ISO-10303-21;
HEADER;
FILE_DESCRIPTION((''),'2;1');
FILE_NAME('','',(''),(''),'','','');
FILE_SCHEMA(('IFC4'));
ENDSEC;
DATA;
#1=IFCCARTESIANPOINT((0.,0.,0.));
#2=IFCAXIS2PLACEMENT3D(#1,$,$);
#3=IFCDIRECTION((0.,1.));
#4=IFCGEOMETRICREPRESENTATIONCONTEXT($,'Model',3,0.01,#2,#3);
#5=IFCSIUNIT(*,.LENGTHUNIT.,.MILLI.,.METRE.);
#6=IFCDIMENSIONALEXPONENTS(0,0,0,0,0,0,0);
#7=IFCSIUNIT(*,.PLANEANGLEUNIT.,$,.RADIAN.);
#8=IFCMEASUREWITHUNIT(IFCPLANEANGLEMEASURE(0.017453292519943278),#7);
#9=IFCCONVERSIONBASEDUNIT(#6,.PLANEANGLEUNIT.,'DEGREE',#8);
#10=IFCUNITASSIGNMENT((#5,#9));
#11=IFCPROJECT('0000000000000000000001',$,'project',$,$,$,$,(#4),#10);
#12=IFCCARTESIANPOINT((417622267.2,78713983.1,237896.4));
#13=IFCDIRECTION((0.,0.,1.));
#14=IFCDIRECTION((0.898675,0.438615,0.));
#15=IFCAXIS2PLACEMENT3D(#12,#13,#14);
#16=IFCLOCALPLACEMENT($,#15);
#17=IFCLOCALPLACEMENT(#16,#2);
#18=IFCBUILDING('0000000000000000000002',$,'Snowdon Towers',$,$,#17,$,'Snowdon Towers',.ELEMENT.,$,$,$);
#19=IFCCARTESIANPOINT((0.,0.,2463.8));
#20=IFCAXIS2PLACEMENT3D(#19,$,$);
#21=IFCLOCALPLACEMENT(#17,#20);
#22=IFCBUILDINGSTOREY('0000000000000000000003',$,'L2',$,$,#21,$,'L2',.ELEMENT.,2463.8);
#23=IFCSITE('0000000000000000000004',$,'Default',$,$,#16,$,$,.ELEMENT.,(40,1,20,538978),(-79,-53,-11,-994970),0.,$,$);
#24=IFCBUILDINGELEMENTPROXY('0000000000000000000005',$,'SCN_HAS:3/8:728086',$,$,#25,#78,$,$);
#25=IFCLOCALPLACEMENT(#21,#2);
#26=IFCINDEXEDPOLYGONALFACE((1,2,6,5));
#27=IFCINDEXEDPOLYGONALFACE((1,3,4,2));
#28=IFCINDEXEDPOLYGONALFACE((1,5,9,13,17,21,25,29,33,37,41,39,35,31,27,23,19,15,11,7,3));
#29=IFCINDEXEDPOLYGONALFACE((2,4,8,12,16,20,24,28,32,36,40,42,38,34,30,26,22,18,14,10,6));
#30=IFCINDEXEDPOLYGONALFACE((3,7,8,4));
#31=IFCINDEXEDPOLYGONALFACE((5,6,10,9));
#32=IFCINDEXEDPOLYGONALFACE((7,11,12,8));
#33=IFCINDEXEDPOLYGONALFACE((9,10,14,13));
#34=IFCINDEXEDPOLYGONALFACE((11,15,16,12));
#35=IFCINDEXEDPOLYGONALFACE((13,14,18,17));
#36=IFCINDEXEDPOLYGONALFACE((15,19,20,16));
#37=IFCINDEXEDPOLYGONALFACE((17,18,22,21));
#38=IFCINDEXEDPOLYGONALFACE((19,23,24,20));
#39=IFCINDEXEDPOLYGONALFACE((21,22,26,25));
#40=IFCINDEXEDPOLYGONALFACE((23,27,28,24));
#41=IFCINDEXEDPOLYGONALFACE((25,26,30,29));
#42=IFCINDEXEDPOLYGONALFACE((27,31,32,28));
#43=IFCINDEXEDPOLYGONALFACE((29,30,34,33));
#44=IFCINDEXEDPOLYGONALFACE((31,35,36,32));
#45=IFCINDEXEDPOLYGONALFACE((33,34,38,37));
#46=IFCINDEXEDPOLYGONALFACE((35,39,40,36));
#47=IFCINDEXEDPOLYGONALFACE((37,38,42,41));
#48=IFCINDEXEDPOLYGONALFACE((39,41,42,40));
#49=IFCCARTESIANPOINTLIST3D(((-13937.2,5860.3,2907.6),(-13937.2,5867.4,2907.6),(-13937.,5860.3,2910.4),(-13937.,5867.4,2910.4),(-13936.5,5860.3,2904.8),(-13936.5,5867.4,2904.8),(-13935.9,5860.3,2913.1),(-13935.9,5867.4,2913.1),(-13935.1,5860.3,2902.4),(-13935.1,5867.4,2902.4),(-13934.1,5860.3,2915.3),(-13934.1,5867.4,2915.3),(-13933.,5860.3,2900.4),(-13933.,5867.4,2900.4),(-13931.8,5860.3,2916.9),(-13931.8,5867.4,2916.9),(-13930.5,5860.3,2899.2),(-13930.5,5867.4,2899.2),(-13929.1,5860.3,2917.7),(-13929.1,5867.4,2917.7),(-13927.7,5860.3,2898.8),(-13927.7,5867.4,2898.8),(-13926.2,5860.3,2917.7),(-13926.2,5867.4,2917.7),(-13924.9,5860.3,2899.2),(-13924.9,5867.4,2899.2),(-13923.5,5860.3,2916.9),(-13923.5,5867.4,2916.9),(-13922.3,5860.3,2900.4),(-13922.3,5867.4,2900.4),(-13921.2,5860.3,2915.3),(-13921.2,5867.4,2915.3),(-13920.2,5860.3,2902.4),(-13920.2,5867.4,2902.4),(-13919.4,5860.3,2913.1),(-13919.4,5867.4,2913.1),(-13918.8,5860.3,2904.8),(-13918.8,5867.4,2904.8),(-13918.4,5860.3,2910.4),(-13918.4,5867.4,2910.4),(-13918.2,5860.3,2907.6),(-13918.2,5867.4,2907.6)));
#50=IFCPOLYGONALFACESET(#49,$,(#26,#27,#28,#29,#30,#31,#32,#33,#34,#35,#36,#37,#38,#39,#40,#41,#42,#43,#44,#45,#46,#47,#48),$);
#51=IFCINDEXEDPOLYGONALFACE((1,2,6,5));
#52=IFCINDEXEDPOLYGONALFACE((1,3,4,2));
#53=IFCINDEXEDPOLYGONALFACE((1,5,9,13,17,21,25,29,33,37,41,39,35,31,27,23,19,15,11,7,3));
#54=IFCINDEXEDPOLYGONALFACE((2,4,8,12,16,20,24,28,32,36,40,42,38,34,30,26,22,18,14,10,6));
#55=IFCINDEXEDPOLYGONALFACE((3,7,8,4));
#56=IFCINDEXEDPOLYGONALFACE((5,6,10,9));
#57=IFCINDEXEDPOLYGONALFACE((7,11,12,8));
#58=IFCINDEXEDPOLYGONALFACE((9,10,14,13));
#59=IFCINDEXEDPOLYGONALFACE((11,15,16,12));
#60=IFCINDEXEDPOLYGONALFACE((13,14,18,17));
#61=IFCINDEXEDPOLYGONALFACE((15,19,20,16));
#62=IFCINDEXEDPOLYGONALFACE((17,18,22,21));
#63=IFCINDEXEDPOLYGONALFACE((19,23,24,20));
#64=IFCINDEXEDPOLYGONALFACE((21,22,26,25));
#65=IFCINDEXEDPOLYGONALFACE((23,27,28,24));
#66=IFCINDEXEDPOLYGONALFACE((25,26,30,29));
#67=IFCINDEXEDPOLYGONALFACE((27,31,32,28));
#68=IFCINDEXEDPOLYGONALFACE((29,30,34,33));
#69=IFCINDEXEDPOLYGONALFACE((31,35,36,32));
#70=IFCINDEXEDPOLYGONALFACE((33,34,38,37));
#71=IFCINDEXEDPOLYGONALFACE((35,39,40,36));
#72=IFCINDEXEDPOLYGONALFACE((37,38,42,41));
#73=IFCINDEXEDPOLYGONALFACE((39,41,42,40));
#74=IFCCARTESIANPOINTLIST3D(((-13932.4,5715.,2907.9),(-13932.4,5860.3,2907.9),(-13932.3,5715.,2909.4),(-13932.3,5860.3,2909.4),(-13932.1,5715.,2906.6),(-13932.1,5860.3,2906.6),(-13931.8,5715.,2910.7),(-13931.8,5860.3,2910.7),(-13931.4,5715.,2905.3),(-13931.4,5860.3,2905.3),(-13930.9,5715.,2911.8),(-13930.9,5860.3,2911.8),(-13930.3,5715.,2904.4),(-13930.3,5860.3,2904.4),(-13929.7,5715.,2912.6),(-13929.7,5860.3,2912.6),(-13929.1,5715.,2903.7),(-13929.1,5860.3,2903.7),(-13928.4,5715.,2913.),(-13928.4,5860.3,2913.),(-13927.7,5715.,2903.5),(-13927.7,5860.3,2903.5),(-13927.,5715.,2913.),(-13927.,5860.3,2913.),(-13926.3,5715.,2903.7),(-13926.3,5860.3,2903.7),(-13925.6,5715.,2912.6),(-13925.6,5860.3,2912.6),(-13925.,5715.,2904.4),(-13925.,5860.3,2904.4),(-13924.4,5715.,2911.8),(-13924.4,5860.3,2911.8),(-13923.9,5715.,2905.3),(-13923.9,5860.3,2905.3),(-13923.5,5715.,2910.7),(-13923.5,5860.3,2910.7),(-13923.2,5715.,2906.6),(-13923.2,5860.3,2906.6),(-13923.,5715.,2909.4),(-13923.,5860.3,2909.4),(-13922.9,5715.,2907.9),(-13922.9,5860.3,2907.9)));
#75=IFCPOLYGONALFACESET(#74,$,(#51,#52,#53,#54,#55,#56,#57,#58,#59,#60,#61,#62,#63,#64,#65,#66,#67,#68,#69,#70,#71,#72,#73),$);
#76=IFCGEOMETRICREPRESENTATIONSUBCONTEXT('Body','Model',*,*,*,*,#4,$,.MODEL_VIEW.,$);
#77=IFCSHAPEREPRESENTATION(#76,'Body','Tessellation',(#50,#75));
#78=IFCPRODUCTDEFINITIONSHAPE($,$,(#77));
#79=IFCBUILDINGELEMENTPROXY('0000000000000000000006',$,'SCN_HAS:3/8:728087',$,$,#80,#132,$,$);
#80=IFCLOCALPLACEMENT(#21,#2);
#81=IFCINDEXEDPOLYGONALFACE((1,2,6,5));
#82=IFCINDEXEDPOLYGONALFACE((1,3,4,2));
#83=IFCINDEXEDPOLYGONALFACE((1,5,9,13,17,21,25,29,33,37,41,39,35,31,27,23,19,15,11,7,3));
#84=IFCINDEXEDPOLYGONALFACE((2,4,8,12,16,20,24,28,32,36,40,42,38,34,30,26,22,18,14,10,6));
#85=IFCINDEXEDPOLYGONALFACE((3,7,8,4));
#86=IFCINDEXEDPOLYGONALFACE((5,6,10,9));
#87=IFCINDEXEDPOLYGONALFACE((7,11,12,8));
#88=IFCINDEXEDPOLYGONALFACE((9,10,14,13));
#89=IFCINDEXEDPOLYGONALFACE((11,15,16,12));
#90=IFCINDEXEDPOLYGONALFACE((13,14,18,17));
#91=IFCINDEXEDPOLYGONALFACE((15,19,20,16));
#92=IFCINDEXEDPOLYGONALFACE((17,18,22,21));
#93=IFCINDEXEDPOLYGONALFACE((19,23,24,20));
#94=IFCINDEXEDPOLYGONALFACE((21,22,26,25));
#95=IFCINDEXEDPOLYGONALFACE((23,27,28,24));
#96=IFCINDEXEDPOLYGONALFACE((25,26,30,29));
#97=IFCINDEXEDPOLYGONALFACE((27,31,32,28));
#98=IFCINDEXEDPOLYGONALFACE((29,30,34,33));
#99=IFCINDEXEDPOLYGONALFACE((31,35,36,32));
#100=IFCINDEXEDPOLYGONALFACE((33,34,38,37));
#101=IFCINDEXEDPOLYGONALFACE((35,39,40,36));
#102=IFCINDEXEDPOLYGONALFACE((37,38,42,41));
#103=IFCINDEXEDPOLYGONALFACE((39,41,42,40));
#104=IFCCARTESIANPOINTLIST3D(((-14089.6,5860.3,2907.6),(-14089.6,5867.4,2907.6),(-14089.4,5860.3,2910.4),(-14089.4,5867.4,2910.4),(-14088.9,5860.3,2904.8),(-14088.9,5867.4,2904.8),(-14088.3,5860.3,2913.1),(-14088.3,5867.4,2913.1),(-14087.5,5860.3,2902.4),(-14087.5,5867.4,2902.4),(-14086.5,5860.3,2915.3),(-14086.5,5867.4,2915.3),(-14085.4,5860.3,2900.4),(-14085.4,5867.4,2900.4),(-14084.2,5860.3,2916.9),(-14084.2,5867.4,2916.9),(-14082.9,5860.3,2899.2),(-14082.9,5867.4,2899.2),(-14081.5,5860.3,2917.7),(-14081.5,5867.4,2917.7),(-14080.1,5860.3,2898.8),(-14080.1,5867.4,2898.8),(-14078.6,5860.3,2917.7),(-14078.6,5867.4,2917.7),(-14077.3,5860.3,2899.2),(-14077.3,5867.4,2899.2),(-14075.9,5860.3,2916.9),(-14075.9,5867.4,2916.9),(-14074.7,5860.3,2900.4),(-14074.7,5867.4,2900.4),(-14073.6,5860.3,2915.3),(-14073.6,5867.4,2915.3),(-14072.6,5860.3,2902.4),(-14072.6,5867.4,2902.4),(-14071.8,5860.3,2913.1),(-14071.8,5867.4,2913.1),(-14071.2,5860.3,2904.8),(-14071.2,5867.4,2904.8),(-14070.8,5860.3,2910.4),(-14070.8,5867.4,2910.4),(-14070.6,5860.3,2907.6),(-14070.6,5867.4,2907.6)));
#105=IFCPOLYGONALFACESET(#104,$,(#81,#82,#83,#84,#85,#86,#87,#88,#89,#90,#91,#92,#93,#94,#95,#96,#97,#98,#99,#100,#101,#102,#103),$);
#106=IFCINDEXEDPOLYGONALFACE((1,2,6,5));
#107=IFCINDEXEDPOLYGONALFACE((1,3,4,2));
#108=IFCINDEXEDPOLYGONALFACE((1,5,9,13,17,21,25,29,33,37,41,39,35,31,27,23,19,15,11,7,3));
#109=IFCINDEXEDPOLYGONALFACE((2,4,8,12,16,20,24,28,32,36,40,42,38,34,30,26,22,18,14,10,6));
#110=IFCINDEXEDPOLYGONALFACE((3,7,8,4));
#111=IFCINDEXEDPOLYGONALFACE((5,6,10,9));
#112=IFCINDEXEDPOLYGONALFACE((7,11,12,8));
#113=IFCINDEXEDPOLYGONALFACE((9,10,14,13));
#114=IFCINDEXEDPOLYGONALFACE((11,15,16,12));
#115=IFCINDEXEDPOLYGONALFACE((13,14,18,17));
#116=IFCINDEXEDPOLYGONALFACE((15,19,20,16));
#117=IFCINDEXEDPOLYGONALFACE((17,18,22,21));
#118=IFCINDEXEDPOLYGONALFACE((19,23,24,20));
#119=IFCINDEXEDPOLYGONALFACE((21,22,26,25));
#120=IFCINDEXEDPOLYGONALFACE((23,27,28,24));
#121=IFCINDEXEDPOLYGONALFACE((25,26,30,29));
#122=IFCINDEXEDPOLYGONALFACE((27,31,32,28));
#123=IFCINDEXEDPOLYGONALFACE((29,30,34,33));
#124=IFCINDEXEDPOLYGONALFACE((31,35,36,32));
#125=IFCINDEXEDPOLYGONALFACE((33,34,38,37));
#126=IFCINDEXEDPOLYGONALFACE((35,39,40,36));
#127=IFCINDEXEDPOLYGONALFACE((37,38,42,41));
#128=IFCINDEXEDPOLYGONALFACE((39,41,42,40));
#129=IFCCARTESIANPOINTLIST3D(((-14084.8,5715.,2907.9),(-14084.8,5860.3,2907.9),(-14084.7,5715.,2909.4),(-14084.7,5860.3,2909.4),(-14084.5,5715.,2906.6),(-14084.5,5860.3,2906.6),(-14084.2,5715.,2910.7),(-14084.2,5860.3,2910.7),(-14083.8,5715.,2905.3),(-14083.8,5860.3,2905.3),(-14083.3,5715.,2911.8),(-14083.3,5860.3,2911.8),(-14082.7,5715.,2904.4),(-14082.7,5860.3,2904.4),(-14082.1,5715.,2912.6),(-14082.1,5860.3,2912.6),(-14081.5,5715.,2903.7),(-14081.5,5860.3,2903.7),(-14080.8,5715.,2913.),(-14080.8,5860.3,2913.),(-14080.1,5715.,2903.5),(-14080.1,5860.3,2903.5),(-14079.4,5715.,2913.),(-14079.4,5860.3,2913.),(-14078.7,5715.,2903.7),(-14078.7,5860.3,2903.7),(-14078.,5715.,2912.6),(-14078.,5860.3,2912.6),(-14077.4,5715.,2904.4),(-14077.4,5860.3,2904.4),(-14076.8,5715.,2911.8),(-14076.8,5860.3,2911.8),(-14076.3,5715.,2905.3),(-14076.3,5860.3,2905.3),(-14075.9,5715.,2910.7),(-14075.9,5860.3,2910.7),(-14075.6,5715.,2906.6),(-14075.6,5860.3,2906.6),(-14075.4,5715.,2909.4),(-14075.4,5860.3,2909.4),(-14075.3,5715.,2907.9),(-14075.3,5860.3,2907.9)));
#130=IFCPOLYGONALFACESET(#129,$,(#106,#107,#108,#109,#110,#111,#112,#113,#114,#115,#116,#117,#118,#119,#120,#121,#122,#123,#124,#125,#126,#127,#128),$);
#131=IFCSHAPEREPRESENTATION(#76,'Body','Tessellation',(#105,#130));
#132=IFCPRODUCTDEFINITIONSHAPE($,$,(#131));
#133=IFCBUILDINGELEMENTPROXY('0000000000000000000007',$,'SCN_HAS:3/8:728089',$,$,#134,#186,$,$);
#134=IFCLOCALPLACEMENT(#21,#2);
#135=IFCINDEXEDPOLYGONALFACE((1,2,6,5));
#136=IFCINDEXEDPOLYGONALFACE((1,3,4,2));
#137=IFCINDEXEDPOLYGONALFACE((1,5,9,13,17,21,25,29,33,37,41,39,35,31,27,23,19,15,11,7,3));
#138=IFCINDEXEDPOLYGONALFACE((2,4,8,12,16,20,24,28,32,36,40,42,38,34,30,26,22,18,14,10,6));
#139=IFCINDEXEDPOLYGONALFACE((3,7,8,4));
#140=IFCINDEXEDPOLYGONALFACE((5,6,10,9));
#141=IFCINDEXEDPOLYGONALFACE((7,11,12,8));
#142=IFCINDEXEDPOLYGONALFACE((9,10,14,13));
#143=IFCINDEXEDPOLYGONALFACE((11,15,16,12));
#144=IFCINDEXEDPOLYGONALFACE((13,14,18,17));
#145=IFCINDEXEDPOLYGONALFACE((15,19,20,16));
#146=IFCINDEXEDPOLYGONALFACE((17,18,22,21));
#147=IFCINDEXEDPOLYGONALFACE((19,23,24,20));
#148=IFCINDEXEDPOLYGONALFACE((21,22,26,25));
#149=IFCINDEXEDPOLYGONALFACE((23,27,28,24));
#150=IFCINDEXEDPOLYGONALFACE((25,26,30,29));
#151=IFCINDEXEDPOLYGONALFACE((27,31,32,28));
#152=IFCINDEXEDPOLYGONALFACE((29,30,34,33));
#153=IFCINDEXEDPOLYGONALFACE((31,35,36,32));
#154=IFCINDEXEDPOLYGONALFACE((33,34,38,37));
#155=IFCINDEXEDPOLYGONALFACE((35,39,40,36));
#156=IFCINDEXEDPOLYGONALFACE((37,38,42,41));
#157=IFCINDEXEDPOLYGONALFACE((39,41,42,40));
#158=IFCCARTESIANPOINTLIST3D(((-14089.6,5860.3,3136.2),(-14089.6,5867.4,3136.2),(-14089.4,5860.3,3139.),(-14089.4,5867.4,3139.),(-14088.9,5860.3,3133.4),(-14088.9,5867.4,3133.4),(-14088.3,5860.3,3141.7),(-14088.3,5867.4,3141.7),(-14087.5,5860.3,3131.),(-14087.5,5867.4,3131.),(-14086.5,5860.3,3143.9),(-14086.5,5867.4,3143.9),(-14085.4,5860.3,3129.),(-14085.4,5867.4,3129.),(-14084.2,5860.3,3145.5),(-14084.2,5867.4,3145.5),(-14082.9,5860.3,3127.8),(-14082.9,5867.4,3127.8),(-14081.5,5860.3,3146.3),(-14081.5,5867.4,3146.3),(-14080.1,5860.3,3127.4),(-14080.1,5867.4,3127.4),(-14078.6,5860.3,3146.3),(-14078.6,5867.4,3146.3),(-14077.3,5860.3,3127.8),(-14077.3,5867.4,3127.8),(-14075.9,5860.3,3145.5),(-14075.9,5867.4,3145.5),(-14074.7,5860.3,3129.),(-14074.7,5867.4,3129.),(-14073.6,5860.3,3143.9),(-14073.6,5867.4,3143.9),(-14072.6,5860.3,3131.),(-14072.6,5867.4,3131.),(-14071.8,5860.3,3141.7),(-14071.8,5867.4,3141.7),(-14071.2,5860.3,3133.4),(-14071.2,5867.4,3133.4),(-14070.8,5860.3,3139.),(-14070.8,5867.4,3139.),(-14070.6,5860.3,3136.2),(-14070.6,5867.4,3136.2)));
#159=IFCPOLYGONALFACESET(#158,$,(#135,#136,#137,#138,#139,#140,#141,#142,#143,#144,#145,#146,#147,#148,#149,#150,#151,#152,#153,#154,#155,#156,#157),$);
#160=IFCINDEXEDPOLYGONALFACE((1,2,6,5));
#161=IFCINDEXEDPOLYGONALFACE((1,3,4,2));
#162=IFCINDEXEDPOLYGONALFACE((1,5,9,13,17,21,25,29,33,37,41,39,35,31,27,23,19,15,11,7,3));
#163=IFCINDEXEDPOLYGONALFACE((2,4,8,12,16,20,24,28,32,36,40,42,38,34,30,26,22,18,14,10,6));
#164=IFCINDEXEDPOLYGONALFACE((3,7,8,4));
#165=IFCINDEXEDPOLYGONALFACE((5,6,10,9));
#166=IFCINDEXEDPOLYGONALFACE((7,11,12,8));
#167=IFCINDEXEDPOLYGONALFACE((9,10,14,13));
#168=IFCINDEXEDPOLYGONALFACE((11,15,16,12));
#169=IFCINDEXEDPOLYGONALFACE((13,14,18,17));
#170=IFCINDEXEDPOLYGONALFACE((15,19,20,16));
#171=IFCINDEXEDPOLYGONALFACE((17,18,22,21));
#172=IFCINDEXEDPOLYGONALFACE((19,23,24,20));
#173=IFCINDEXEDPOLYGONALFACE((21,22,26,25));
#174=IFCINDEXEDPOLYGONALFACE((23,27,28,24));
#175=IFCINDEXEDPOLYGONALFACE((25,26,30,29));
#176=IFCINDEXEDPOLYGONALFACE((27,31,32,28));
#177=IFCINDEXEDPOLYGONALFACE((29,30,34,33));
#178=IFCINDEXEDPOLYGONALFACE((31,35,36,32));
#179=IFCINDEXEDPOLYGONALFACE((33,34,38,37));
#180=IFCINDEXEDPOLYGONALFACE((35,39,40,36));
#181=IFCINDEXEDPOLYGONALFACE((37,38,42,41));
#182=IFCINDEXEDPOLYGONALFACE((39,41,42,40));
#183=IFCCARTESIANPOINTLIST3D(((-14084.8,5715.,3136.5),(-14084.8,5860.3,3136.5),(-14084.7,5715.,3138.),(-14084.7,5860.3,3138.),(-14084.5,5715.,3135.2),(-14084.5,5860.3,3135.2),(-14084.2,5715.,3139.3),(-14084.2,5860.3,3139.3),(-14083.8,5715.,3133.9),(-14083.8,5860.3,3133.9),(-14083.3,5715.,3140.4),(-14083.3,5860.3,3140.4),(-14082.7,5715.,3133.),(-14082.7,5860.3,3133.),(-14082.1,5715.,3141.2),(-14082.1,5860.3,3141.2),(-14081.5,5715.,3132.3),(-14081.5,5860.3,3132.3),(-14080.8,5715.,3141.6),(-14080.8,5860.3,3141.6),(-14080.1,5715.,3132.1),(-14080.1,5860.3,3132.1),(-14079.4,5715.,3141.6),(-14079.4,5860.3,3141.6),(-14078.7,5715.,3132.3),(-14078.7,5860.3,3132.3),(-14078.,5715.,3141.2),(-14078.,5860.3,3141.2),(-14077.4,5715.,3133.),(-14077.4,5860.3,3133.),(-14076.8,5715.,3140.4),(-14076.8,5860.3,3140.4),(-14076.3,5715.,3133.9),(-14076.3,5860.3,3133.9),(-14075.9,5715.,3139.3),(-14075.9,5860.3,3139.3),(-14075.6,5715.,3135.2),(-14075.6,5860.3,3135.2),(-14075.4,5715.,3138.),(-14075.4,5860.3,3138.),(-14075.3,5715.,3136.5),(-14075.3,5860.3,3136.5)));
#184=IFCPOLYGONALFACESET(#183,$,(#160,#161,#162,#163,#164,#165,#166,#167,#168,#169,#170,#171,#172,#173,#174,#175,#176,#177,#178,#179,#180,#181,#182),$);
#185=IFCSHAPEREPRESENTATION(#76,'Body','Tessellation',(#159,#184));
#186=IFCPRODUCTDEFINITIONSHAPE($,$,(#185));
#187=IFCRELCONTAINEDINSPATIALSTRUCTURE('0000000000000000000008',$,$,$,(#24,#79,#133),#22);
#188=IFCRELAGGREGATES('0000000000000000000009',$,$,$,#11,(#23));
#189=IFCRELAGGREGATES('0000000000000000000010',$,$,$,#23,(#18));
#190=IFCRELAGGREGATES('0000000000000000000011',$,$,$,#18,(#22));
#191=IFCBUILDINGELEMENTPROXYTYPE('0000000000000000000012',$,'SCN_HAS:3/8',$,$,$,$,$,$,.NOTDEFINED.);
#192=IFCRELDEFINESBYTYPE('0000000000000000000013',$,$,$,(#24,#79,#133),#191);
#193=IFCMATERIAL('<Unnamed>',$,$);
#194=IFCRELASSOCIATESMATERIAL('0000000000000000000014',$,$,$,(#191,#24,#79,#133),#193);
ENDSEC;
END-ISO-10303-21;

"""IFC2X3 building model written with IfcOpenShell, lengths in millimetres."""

from ifc_helpers import new_model, entity, si_unit, converted_unit, direction, frame, frame_2d, origin, place, context, subcontext, project, spatial, circle, extrude, source, transform, mapped, material, type_object, type_shapes, element, save


model = new_model("IFC2X3")

# Units and contexts
model_context = context("Model", 3, precision=0.01, world=origin(), true_north=direction((0.0, 1.0)))
body_context = subcontext(model_context, "Body", "Model", "MODEL_VIEW")
ifc_project = project(units=[si_unit("LENGTHUNIT", "METRE", prefix="MILLI"), converted_unit("PLANEANGLEUNIT", "DEGREE", entity("IfcPlaneAngleMeasure", 0.017453292519943278), si_unit("PLANEANGLEUNIT", "RADIAN"), dimensions=[0, 0, 0, 0, 0, 0, 0])], contexts=[model_context])

# Site, building, storey
site_placement = place(None, frame((417622267.2, 78713983.1, 237896.4), z_axis=(0.0, 0.0, 1.0), x_axis=(0.898675, 0.438615, 0.0)))
site = spatial("IfcSite", under=ifc_project, at=site_placement, Name="Default", CompositionType="ELEMENT", RefLatitude=(40, 1, 20, 538978), RefLongitude=(-79, -53, -11, -994970), RefElevation=0.0)
building_placement = place(site_placement, origin())
building = spatial("IfcBuilding", under=site, at=building_placement, Name="Snowdon Towers", LongName="Snowdon Towers", CompositionType="ELEMENT")
storey_placement = place(building_placement, frame((0.0, 0.0, 2463.8)))
storey = spatial("IfcBuildingStorey", under=building, at=storey_placement, Name="L2", LongName="L2", CompositionType="ELEMENT", Elevation=2463.8)

# Building element proxies
ifc_material_1 = material(Name="<Unnamed>")
building_element_proxy_type_1 = type_object("IfcBuildingElementProxyType", Name="SCN_HAS:3/8", PredefinedType="NOTDEFINED", material=ifc_material_1)
shared_shape_1 = source(origin(), body_context, "Body", "SweptSolid", [
    extrude(circle(Radius=9.5, at=frame_2d((0.0, 0.0), x_axis=(1.0, 0.0))), frame((0.0, 0.0, -152.4), z_axis=(0.0, 0.0, 1.0), x_axis=(0.0, -1.0, 0.0)), (0.0, 0.0, 1.0), 7.1),
    extrude(circle(Radius=4.8, at=frame_2d((0.0, 0.0), x_axis=(1.0, 0.0))), frame((0.0, 0.0, -145.3), z_axis=(0.0, 0.0, 1.0), x_axis=(0.0, -1.0, 0.0)), (0.0, 0.0, 1.0), 145.3),
])
type_shapes(building_element_proxy_type_1, [shared_shape_1])
for number, where, z_axis, x_axis, name in (
    (1, (-13927.7, 5715.0, 2908.3), (0.0, -1.0, 0.0), (1.0, 0.0, 0.0), "SCN_HAS:3/8:728086"),
    (2, (-14080.1, 5715.0, 2908.3), (0.0, -1.0, 0.0), (1.0, 0.0, 0.0), "SCN_HAS:3/8:728087"),
    (3, (-14080.1, 5715.0, 3136.9), (0.0, -1.0, 0.0), (1.0, 0.0, 0.0), "SCN_HAS:3/8:728089"),
):
    element("IfcBuildingElementProxy", number, at=place(storey_placement, frame(where, z_axis=z_axis, x_axis=x_axis)), inside=storey, type_object=building_element_proxy_type_1, material=ifc_material_1, Name=name, context=body_context, shape_type="MappedRepresentation", body=[
        mapped(shared_shape_1, transform((0.0, 0.0, 0.0), scale=1.0)),
    ])

save(model, "model.ifc")
